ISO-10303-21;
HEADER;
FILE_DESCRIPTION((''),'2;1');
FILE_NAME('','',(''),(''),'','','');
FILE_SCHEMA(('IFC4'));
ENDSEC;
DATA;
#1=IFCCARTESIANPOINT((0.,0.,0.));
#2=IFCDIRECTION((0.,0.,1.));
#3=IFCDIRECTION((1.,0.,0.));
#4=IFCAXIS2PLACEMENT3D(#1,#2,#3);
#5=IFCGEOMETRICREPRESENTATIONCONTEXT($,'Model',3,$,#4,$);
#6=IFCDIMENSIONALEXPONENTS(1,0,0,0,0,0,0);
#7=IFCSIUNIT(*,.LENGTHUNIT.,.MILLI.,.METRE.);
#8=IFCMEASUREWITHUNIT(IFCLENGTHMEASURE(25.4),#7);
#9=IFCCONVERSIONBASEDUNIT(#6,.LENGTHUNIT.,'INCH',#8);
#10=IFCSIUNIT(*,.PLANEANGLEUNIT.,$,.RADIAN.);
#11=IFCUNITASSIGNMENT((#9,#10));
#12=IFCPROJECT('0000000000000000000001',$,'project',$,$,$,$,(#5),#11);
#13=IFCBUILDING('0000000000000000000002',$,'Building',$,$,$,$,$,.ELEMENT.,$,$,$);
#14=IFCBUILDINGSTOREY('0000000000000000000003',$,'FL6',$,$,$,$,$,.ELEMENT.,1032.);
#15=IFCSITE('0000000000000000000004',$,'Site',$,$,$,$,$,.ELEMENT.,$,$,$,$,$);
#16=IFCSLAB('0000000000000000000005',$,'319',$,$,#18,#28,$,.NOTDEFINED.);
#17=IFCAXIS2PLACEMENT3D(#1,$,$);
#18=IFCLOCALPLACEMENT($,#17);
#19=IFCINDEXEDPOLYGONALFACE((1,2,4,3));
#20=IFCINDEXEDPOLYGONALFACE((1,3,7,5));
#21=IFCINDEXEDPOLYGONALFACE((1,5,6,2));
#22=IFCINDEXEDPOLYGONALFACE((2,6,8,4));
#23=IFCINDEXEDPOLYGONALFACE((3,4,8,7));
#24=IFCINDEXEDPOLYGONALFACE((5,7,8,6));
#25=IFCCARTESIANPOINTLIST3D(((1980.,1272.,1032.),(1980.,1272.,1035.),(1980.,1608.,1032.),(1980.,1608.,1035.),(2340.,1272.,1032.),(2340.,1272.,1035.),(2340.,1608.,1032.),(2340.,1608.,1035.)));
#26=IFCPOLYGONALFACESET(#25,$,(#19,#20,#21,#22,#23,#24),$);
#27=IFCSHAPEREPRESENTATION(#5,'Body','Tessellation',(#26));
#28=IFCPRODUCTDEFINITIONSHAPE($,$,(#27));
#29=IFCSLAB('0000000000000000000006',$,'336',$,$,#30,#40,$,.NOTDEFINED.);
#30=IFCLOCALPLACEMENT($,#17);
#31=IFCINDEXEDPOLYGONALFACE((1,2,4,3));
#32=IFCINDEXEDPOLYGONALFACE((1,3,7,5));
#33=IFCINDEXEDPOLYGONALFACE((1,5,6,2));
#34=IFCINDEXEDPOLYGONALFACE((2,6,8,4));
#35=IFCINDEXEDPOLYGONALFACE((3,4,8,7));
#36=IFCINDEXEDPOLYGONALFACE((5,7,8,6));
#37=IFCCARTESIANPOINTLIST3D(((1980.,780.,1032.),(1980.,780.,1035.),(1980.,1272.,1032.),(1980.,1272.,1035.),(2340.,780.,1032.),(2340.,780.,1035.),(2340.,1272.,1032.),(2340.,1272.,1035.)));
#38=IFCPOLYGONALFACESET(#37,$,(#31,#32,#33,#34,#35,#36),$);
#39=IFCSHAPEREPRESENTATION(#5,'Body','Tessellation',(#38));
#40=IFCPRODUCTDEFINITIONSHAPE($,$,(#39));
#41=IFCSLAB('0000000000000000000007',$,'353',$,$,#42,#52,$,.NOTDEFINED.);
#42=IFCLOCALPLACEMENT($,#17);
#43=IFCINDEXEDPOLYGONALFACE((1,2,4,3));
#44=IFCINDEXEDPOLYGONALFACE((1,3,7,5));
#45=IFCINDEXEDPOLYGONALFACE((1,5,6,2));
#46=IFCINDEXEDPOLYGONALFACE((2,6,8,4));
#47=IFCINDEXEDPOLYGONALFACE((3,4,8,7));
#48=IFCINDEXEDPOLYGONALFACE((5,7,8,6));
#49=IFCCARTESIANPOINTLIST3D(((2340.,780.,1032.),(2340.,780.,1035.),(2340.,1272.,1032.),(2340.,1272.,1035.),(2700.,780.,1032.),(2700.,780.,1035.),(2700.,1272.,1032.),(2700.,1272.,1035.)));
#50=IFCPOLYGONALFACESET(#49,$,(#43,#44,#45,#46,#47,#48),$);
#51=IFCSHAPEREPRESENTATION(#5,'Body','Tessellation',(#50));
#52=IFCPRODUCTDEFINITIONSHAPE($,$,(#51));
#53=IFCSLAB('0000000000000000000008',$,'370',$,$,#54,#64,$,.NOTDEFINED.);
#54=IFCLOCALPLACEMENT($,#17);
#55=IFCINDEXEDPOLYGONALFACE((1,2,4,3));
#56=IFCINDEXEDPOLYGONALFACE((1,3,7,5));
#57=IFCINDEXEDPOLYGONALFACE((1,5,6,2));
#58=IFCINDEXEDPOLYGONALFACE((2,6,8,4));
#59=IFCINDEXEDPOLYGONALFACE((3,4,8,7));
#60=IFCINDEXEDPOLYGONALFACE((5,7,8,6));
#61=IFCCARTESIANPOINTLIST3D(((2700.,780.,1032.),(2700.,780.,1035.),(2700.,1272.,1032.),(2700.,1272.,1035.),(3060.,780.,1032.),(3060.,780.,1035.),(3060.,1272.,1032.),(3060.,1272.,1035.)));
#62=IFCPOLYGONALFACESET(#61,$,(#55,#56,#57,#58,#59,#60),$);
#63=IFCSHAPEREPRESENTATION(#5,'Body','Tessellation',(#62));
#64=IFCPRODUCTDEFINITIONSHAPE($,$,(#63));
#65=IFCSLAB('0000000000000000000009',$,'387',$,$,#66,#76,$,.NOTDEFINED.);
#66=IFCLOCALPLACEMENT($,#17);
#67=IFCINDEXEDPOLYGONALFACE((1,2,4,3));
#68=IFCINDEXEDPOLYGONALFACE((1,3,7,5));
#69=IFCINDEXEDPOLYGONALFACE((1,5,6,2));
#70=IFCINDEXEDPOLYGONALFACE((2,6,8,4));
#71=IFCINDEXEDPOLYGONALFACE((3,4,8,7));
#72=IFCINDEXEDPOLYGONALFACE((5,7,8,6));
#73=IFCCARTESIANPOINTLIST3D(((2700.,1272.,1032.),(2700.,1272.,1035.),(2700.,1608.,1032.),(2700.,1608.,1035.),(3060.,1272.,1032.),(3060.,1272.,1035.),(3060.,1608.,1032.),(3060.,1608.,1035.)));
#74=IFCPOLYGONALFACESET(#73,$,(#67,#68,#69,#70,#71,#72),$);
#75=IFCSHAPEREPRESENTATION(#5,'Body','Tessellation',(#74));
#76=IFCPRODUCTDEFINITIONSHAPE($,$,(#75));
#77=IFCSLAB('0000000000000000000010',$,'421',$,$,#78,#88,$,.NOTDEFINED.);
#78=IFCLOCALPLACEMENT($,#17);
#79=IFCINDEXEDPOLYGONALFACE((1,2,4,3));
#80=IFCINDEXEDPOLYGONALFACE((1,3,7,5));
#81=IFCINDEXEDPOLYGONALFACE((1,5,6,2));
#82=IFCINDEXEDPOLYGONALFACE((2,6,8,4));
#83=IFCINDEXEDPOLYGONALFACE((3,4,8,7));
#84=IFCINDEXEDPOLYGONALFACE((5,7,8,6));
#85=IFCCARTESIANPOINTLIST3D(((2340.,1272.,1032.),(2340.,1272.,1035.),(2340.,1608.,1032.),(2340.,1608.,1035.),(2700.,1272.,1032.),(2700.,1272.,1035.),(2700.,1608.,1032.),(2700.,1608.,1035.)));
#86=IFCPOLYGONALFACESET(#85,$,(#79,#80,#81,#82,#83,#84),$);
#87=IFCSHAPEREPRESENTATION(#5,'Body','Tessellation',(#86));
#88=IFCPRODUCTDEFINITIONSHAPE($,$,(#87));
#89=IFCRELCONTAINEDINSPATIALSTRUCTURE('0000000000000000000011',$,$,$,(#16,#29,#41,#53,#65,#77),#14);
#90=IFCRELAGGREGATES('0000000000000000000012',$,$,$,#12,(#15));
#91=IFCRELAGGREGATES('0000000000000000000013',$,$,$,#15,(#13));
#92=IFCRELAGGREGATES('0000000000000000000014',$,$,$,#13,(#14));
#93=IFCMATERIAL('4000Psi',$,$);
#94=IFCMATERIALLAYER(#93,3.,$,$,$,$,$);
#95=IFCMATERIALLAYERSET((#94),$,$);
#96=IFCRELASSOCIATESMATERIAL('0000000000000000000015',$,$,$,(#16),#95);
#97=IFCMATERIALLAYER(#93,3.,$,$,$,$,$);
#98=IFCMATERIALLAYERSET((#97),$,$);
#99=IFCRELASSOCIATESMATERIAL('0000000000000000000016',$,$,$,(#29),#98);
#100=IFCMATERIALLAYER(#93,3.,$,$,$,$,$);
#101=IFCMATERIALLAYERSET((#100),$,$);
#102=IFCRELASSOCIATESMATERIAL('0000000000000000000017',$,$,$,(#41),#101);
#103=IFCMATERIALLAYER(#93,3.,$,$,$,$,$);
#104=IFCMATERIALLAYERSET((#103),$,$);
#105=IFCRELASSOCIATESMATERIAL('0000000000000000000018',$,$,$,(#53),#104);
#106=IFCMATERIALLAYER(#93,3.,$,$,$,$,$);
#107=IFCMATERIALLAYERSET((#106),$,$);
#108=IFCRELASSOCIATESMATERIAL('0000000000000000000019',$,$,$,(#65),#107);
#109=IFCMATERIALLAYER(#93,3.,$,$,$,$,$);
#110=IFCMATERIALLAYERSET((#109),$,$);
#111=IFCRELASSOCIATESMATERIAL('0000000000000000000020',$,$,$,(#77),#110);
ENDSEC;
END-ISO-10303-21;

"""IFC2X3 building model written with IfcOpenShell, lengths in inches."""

from ifc_helpers import new_model, entity, si_unit, converted_unit, frame, origin_with_axes, place, context, project, spatial, polyline, outline, extrude, material, layer, layer_set, layer_usage, element, save


model = new_model("IFC2X3")

# Units and contexts
model_context = context("Model", 3, world=origin_with_axes())
ifc_project = project(units=[converted_unit("LENGTHUNIT", "INCH", entity("IfcLengthMeasure", 25.4), si_unit("LENGTHUNIT", "METRE", prefix="MILLI"), dimensions=[1, 0, 0, 0, 0, 0, 0]), si_unit("PLANEANGLEUNIT", "RADIAN")], contexts=[model_context])

# Site, building, storey
site = spatial("IfcSite", under=ifc_project, Name="Site", CompositionType="ELEMENT")
building = spatial("IfcBuilding", under=site, Name="Building", CompositionType="ELEMENT")
storey = spatial("IfcBuildingStorey", under=building, Name="FL6", CompositionType="ELEMENT", Elevation=1032.0)

# Slabs
ifc_material_1 = material(Name="4000Psi")
ifc_layer_1 = layer(ifc_material_1, 3.0)
ifc_layer_set_1 = layer_set([ifc_layer_1])
ifc_layer_usage_1 = layer_usage(ifc_layer_set_1, "AXIS2", "POSITIVE", -3.0)
slab_1_placement = place(None, frame((1980.0, 1272.0, 1032.0), z_axis=(0.0, 0.0, 1.0), x_axis=(1.0, 0.0, 0.0)))
element("IfcSlab", 1, at=slab_1_placement, inside=storey, material=ifc_layer_usage_1, Name="319", PredefinedType="NOTDEFINED", context=model_context, shape_type="SweptSolid", body=[
    extrude(outline(polyline([(0.0, 0.0), (360.0, 0.0), (360.0, 336.0), (0.0, 336.0), (0.0, 0.0)])), origin_with_axes(), (0.0, 0.0, 1.0), 3.0),
])
ifc_layer_2 = layer(ifc_material_1, 3.0)
ifc_layer_set_2 = layer_set([ifc_layer_2])
ifc_layer_usage_2 = layer_usage(ifc_layer_set_2, "AXIS2", "POSITIVE", -3.0)
slab_2_placement = place(None, frame((1980.0, 780.0, 1032.0), z_axis=(0.0, 0.0, 1.0), x_axis=(1.0, 0.0, 0.0)))
element("IfcSlab", 2, at=slab_2_placement, inside=storey, material=ifc_layer_usage_2, Name="336", PredefinedType="NOTDEFINED", context=model_context, shape_type="SweptSolid", body=[
    extrude(outline(polyline([(0.0, 0.0), (360.0, 0.0), (360.0, 492.0), (0.0, 492.0), (0.0, 0.0)])), origin_with_axes(), (0.0, 0.0, 1.0), 3.0),
])
ifc_layer_3 = layer(ifc_material_1, 3.0)
ifc_layer_set_3 = layer_set([ifc_layer_3])
ifc_layer_usage_3 = layer_usage(ifc_layer_set_3, "AXIS2", "POSITIVE", -3.0)
slab_3_placement = place(None, frame((2340.0, 780.0, 1032.0), z_axis=(0.0, 0.0, 1.0), x_axis=(1.0, 0.0, 0.0)))
element("IfcSlab", 3, at=slab_3_placement, inside=storey, material=ifc_layer_usage_3, Name="353", PredefinedType="NOTDEFINED", context=model_context, shape_type="SweptSolid", body=[
    extrude(outline(polyline([(0.0, 0.0), (360.0, 0.0), (360.0, 492.0), (0.0, 492.0), (0.0, 0.0)])), origin_with_axes(), (0.0, 0.0, 1.0), 3.0),
])
ifc_layer_4 = layer(ifc_material_1, 3.0)
ifc_layer_set_4 = layer_set([ifc_layer_4])
ifc_layer_usage_4 = layer_usage(ifc_layer_set_4, "AXIS2", "POSITIVE", -3.0)
slab_4_placement = place(None, frame((2700.0, 780.0, 1032.0), z_axis=(0.0, 0.0, 1.0), x_axis=(1.0, 0.0, 0.0)))
element("IfcSlab", 4, at=slab_4_placement, inside=storey, material=ifc_layer_usage_4, Name="370", PredefinedType="NOTDEFINED", context=model_context, shape_type="SweptSolid", body=[
    extrude(outline(polyline([(0.0, 0.0), (360.0, 0.0), (360.0, 492.0), (0.0, 492.0), (0.0, 0.0)])), origin_with_axes(), (0.0, 0.0, 1.0), 3.0),
])
ifc_layer_5 = layer(ifc_material_1, 3.0)
ifc_layer_set_5 = layer_set([ifc_layer_5])
ifc_layer_usage_5 = layer_usage(ifc_layer_set_5, "AXIS2", "POSITIVE", -3.0)
slab_5_placement = place(None, frame((2700.0, 1272.0, 1032.0), z_axis=(0.0, 0.0, 1.0), x_axis=(1.0, 0.0, 0.0)))
element("IfcSlab", 5, at=slab_5_placement, inside=storey, material=ifc_layer_usage_5, Name="387", PredefinedType="NOTDEFINED", context=model_context, shape_type="SweptSolid", body=[
    extrude(outline(polyline([(0.0, 0.0), (360.0, 0.0), (360.0, 336.0), (0.0, 336.0), (0.0, 0.0)])), origin_with_axes(), (0.0, 0.0, 1.0), 3.0),
])
ifc_layer_6 = layer(ifc_material_1, 3.0)
ifc_layer_set_6 = layer_set([ifc_layer_6])
ifc_layer_usage_6 = layer_usage(ifc_layer_set_6, "AXIS2", "POSITIVE", -3.0)
slab_6_placement = place(None, frame((2340.0, 1272.0, 1032.0), z_axis=(0.0, 0.0, 1.0), x_axis=(1.0, 0.0, 0.0)))
element("IfcSlab", 6, at=slab_6_placement, inside=storey, material=ifc_layer_usage_6, Name="421", PredefinedType="NOTDEFINED", context=model_context, shape_type="SweptSolid", body=[
    extrude(outline(polyline([(0.0, 0.0), (360.0, 0.0), (360.0, 336.0), (0.0, 336.0), (0.0, 0.0)])), origin_with_axes(), (0.0, 0.0, 1.0), 3.0),
])

save(model, "model.ifc")
